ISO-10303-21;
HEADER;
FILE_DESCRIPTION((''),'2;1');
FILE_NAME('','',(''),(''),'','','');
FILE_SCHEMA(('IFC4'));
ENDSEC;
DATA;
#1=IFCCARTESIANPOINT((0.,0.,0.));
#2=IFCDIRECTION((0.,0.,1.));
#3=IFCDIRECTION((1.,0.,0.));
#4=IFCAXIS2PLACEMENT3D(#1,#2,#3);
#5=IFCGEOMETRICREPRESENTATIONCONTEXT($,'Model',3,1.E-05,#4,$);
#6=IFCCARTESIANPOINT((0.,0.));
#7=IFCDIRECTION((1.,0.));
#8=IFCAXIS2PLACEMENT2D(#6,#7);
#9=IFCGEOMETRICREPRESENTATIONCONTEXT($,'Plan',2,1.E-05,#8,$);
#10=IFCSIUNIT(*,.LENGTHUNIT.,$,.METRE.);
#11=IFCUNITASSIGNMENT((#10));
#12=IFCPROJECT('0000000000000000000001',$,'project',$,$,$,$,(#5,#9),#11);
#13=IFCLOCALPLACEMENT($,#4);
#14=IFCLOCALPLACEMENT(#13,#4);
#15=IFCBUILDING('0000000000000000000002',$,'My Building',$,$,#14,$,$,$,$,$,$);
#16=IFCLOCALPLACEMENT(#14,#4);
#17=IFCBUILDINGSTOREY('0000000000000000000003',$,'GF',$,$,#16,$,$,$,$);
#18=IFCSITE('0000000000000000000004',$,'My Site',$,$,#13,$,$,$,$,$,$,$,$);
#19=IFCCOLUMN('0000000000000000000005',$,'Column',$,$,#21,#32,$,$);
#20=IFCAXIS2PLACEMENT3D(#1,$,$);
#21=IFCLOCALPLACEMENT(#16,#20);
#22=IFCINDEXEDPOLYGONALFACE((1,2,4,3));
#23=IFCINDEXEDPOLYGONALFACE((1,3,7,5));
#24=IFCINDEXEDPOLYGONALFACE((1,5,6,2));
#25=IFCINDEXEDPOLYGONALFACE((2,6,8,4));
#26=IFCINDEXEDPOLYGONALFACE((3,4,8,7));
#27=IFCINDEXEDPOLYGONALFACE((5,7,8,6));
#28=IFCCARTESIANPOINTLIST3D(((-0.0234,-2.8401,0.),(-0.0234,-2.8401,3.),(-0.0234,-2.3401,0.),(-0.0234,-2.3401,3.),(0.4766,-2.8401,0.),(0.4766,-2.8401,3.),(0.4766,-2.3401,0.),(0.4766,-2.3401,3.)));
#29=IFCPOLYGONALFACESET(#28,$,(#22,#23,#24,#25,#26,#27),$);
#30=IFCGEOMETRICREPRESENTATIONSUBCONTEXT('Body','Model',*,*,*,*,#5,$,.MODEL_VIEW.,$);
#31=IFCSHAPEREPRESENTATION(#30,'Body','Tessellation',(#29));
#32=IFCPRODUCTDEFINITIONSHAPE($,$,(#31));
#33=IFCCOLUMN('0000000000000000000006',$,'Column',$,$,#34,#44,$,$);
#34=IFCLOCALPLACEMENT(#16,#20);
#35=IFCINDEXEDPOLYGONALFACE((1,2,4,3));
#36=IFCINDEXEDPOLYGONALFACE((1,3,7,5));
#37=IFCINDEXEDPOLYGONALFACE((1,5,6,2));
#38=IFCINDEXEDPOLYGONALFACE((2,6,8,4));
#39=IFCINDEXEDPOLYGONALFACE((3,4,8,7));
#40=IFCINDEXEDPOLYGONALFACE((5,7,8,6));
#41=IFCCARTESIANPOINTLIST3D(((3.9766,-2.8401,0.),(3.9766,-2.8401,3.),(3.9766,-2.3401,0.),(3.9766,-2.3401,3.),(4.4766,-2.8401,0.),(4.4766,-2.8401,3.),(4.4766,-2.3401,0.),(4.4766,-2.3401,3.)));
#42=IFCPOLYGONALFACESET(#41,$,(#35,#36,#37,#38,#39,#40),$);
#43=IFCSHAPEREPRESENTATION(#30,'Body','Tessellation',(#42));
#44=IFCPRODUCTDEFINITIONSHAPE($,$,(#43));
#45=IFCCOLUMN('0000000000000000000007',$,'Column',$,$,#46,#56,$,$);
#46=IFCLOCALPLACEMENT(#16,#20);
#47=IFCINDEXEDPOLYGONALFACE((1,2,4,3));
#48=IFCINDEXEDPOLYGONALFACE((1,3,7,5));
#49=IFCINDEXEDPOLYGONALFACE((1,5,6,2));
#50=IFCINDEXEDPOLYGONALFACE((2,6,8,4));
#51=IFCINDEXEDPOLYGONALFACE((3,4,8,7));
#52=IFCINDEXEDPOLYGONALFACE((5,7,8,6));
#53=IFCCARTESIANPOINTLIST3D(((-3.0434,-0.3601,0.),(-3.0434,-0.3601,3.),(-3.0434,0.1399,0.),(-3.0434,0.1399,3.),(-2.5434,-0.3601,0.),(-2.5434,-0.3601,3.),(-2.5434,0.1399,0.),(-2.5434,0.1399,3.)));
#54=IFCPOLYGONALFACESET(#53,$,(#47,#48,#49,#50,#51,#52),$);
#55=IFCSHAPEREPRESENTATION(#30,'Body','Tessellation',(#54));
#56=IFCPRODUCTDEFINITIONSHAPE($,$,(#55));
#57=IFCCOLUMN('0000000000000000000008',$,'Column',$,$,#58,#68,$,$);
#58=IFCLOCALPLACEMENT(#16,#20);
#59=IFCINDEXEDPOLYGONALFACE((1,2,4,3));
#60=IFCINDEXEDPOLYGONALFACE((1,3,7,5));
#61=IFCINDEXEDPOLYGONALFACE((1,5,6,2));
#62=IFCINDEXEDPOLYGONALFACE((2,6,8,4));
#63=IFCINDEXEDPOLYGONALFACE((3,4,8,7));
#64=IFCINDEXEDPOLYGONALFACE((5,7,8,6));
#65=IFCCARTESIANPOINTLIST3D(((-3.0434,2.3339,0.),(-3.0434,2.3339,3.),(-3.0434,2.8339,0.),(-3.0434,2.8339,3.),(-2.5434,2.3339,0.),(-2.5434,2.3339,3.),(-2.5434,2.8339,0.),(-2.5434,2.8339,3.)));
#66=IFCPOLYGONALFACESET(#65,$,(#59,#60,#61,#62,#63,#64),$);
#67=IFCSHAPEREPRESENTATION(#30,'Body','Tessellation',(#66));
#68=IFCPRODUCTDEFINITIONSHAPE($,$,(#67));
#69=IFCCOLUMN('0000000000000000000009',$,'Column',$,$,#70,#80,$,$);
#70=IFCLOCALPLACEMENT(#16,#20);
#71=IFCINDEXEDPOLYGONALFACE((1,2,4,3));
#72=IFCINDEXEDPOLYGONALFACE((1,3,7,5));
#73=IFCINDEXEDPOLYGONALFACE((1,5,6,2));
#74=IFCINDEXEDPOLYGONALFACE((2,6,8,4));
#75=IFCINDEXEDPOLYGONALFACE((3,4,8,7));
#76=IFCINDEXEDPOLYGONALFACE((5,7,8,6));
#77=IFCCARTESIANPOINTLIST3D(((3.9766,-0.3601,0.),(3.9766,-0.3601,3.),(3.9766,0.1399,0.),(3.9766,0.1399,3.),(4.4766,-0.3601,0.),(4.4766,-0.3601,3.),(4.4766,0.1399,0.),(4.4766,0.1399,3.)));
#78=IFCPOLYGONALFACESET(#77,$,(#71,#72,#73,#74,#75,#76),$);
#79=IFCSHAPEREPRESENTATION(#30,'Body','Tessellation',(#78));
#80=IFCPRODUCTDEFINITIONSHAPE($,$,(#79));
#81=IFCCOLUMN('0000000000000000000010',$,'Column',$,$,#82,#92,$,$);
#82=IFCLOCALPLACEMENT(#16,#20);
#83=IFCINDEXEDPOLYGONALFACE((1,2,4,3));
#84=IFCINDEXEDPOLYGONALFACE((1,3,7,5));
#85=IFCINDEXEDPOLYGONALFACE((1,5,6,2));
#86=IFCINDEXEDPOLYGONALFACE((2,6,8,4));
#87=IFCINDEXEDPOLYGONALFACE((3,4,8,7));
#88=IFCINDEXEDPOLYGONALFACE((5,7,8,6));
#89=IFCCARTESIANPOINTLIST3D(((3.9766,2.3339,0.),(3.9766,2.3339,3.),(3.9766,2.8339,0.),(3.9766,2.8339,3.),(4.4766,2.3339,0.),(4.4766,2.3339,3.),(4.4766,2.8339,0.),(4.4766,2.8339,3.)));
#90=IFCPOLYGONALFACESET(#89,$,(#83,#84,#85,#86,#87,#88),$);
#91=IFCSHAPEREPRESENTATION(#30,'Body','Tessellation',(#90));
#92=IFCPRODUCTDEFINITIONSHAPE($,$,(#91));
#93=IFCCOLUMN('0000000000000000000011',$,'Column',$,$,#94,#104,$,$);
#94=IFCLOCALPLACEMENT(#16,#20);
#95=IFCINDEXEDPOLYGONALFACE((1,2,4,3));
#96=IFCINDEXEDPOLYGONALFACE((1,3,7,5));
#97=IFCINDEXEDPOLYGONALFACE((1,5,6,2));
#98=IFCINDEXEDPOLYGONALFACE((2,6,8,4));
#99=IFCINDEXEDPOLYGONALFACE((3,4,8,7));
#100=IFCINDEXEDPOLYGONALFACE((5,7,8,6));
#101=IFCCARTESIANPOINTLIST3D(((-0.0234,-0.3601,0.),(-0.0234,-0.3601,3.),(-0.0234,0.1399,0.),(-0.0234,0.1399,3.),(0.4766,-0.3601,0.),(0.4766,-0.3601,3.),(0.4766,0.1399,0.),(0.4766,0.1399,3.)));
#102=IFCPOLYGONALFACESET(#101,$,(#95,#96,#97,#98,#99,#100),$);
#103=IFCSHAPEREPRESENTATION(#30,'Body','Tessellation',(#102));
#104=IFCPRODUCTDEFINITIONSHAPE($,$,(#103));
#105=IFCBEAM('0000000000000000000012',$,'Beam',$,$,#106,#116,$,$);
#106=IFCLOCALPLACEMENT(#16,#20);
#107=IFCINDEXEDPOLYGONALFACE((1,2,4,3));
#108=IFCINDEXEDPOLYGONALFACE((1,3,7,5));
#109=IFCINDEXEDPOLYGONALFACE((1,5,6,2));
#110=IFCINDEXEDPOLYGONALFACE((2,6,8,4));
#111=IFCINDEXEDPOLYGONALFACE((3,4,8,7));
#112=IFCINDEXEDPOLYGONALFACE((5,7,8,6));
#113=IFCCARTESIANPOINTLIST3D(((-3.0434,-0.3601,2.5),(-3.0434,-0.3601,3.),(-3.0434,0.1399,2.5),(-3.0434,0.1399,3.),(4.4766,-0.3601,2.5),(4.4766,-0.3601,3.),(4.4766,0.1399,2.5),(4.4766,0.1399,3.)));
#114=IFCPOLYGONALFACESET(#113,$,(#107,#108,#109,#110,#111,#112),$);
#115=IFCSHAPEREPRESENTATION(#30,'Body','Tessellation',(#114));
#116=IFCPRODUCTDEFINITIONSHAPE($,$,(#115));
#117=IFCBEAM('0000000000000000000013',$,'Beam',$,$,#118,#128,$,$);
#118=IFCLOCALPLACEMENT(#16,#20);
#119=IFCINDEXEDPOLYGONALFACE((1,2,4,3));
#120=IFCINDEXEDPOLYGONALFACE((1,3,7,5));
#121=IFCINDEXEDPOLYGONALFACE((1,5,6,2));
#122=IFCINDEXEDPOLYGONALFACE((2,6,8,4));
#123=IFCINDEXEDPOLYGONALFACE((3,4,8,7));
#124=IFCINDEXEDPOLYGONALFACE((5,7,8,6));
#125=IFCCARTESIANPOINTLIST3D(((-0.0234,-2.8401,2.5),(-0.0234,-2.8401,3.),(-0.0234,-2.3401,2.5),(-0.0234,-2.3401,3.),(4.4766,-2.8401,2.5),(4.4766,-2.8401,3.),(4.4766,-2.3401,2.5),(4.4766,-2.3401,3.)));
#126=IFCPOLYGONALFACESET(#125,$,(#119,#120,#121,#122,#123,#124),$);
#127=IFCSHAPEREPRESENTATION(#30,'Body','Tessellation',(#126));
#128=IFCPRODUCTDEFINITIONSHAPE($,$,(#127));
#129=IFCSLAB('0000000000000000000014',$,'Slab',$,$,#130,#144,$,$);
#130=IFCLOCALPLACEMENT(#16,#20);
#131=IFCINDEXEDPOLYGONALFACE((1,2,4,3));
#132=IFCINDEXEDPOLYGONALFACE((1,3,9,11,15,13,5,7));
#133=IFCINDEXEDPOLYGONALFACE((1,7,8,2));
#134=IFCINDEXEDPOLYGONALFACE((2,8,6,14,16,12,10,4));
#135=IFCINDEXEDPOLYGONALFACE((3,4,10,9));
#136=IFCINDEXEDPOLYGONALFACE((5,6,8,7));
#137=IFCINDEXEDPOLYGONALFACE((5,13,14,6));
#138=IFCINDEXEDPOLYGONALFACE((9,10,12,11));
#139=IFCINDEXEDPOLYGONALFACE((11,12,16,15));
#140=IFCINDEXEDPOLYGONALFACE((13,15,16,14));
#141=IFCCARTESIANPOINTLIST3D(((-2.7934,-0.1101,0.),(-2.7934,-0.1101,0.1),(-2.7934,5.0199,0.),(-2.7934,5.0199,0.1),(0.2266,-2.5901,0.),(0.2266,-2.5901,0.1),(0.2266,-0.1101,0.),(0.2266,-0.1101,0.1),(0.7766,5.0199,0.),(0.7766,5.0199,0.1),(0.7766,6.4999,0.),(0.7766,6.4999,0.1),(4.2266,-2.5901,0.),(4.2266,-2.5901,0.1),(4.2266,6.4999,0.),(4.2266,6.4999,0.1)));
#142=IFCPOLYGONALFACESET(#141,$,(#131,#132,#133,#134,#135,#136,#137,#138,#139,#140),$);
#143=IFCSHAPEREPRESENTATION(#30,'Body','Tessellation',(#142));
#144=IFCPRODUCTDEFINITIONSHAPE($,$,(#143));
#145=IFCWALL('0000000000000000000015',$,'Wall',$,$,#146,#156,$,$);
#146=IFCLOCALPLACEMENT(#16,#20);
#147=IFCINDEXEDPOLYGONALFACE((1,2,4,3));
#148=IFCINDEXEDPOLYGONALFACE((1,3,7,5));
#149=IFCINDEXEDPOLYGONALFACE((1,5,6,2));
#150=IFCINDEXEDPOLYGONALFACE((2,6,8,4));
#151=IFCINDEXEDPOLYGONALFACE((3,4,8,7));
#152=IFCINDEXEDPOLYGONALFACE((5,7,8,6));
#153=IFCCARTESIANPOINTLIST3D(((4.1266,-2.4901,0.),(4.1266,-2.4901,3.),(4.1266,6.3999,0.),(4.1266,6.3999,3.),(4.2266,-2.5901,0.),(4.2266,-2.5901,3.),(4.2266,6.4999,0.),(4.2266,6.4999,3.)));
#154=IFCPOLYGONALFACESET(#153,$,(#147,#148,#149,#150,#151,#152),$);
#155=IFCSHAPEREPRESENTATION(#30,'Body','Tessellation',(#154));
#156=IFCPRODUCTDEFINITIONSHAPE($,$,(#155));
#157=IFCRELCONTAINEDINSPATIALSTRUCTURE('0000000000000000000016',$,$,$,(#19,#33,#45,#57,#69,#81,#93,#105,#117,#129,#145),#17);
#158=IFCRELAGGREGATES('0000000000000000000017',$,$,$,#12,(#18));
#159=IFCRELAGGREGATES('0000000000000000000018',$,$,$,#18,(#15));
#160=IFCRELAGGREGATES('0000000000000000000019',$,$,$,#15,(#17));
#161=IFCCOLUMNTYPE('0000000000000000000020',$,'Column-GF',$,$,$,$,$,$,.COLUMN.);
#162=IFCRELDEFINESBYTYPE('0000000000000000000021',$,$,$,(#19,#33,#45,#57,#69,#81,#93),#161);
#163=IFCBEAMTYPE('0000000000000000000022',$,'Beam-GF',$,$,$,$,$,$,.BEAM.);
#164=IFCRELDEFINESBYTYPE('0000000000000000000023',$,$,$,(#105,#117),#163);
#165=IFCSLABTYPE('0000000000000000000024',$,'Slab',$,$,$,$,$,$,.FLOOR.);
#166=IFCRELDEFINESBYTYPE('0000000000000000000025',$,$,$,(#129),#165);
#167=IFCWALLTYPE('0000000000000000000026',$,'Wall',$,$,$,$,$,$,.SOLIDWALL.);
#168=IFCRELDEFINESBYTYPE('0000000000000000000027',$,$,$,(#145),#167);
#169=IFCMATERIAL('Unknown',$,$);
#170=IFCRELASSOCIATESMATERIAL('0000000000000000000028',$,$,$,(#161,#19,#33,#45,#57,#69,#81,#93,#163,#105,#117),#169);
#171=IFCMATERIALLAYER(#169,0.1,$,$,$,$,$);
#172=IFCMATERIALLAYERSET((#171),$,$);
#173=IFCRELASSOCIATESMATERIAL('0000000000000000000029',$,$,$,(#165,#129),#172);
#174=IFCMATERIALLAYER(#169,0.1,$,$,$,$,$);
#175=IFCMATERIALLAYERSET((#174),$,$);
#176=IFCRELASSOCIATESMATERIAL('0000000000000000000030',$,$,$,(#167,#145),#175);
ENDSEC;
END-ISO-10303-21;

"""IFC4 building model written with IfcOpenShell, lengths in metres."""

from ifc_helpers import new_model, si_unit, frame, origin_with_axes, origin_2d_with_axis, place, context, subcontext, project, spatial, line, indexed_curve, rectangle, outline, extrude, material, layer, layer_set, layer_usage, material_profile, profile_set, profile_usage, type_object, element, save


model = new_model("IFC4")

# Units and contexts
model_context = context("Model", 3, precision=1e-05, world=origin_with_axes())
plan_context = context("Plan", 2, precision=1e-05, world=origin_2d_with_axis())
body_context_1 = subcontext(model_context, "Body", "Model", "MODEL_VIEW")
ifc_project = project(units=[si_unit("LENGTHUNIT", "METRE")], contexts=[model_context, plan_context])

# Site, building, storey
site_placement = place(None, origin_with_axes())
site = spatial("IfcSite", under=ifc_project, at=site_placement, Name="My Site")
building_placement = place(site_placement, origin_with_axes())
building = spatial("IfcBuilding", under=site, at=building_placement, Name="My Building")
storey_placement = place(building_placement, origin_with_axes())
storey = spatial("IfcBuildingStorey", under=building, at=storey_placement, Name="GF")

# Columns
ifc_material = material(Name="Unknown")
ifc_material_profile_1 = material_profile(ifc_material, rectangle(XDim=0.5, YDim=0.5))
ifc_profile_set_1 = profile_set([ifc_material_profile_1])
ifc_profile_usage_1 = profile_usage(ifc_profile_set_1, cardinal=5)
column_type = type_object("IfcColumnType", Name="Column-GF", PredefinedType="COLUMN", material=ifc_profile_set_1)
column_1_placement = place(storey_placement, frame((0.2266, -2.5901, 0.0), z_axis=(0.0, 0.0, 1.0), x_axis=(1.0, 0.0, 0.0)))
element("IfcColumn", 1, at=column_1_placement, inside=storey, type_object=column_type, material=ifc_profile_usage_1, Name="Column", context=body_context_1, shape_type="SweptSolid", body=[
    extrude(rectangle(XDim=0.5, YDim=0.5), origin_with_axes(), (0.0, 0.0, 1.0), 3.0),
])
ifc_profile_usage_2 = profile_usage(ifc_profile_set_1, cardinal=5)
column_2_placement = place(storey_placement, frame((4.2266, -2.5901, 0.0), z_axis=(0.0, 0.0, 1.0), x_axis=(1.0, 0.0, 0.0)))
element("IfcColumn", 2, at=column_2_placement, inside=storey, type_object=column_type, material=ifc_profile_usage_2, Name="Column", context=body_context_1, shape_type="SweptSolid", body=[
    extrude(rectangle(XDim=0.5, YDim=0.5), origin_with_axes(), (0.0, 0.0, 1.0), 3.0),
])
ifc_profile_usage_3 = profile_usage(ifc_profile_set_1, cardinal=5)
column_3_placement = place(storey_placement, frame((-2.7934, -0.1101, 0.0), z_axis=(0.0, 0.0, 1.0), x_axis=(1.0, 0.0, 0.0)))
element("IfcColumn", 3, at=column_3_placement, inside=storey, type_object=column_type, material=ifc_profile_usage_3, Name="Column", context=body_context_1, shape_type="SweptSolid", body=[
    extrude(rectangle(XDim=0.5, YDim=0.5), origin_with_axes(), (0.0, 0.0, 1.0), 3.0),
])
ifc_profile_usage_4 = profile_usage(ifc_profile_set_1, cardinal=5)
column_4_placement = place(storey_placement, frame((-2.7934, 2.5839, 0.0), z_axis=(0.0, 0.0, 1.0), x_axis=(1.0, 0.0, 0.0)))
element("IfcColumn", 4, at=column_4_placement, inside=storey, type_object=column_type, material=ifc_profile_usage_4, Name="Column", context=body_context_1, shape_type="SweptSolid", body=[
    extrude(rectangle(XDim=0.5, YDim=0.5), origin_with_axes(), (0.0, 0.0, 1.0), 3.0),
])
ifc_profile_usage_5 = profile_usage(ifc_profile_set_1, cardinal=5)
column_5_placement = place(storey_placement, frame((4.2266, -0.1101, 0.0), z_axis=(0.0, 0.0, 1.0), x_axis=(1.0, 0.0, 0.0)))
element("IfcColumn", 5, at=column_5_placement, inside=storey, type_object=column_type, material=ifc_profile_usage_5, Name="Column", context=body_context_1, shape_type="SweptSolid", body=[
    extrude(rectangle(XDim=0.5, YDim=0.5), origin_with_axes(), (0.0, 0.0, 1.0), 3.0),
])
ifc_profile_usage_6 = profile_usage(ifc_profile_set_1, cardinal=5)
column_6_placement = place(storey_placement, frame((4.2266, 2.5839, 0.0), z_axis=(0.0, 0.0, 1.0), x_axis=(1.0, 0.0, 0.0)))
element("IfcColumn", 6, at=column_6_placement, inside=storey, type_object=column_type, material=ifc_profile_usage_6, Name="Column", context=body_context_1, shape_type="SweptSolid", body=[
    extrude(rectangle(XDim=0.5, YDim=0.5), origin_with_axes(), (0.0, 0.0, 1.0), 3.0),
])
ifc_profile_usage_7 = profile_usage(ifc_profile_set_1, cardinal=5)
column_7_placement = place(storey_placement, frame((0.2266, -0.1101, 0.0), z_axis=(0.0, 0.0, 1.0), x_axis=(1.0, 0.0, 0.0)))
element("IfcColumn", 7, at=column_7_placement, inside=storey, type_object=column_type, material=ifc_profile_usage_7, Name="Column", context=body_context_1, shape_type="SweptSolid", body=[
    extrude(rectangle(XDim=0.5, YDim=0.5), origin_with_axes(), (0.0, 0.0, 1.0), 3.0),
])

# Beams
ifc_material_profile_2 = material_profile(ifc_material, rectangle(XDim=0.5, YDim=0.5))
ifc_profile_set_2 = profile_set([ifc_material_profile_2])
ifc_profile_usage_8 = profile_usage(ifc_profile_set_2, cardinal=7)
beam_type = type_object("IfcBeamType", Name="Beam-GF", PredefinedType="BEAM", material=ifc_profile_set_2)
beam_1_placement = place(storey_placement, frame((-3.0434, 0.1399, 3.0), z_axis=(1.0, 0.0, 0.0), x_axis=(0.0, 1.0, 0.0)))
element("IfcBeam", 8, at=beam_1_placement, inside=storey, type_object=beam_type, material=ifc_profile_usage_8, Name="Beam", context=body_context_1, shape_type="SweptSolid", body=[
    extrude(rectangle(XDim=0.5, YDim=0.5), frame((-0.25, -0.25, 0.0), z_axis=(0.0, 0.0, 1.0), x_axis=(1.0, 0.0, 0.0)), (0.0, 0.0, 1.0), 7.52),
])
ifc_profile_usage_9 = profile_usage(ifc_profile_set_2, cardinal=7)
beam_2_placement = place(storey_placement, frame((-0.0234, -2.3401, 3.0), z_axis=(1.0, -0.000001, 0.000001), x_axis=(0.000001, 1.0, 0.0)))
element("IfcBeam", 9, at=beam_2_placement, inside=storey, type_object=beam_type, material=ifc_profile_usage_9, Name="Beam", context=body_context_1, shape_type="SweptSolid", body=[
    extrude(rectangle(XDim=0.5, YDim=0.5), frame((-0.25, -0.25, 0.0), z_axis=(0.0, 0.0, 1.0), x_axis=(1.0, 0.0, 0.0)), (0.0, 0.0, 1.0), 4.5),
])

# Slab
ifc_layer_1 = layer(ifc_material, 0.1)
ifc_layer_set_1 = layer_set([ifc_layer_1])
ifc_layer_usage_1 = layer_usage(ifc_layer_set_1, "AXIS3", "POSITIVE", -0.1)
slab_type_1 = type_object("IfcSlabType", Name="Slab", PredefinedType="FLOOR", material=ifc_layer_set_1)
slab_1_placement = place(storey_placement, frame((4.2266, -2.5901, 0.1), z_axis=(0.0, 0.0, 1.0), x_axis=(1.0, 0.0, 0.0)))
element("IfcSlab", 10, at=slab_1_placement, inside=storey, type_object=slab_type_1, material=ifc_layer_usage_1, Name="Slab", context=body_context_1, shape_type="SweptSolid", body=[
    extrude(outline(indexed_curve([(0.0, 0.0), (0.0, 9.09), (-3.45, 9.09), (-3.45, 7.61), (-7.02, 7.61), (-7.02, 2.48), (-4.0, 2.48), (-4.0, 0.0), (0.0, 0.0)])), frame((0.0, 0.0, -0.1), z_axis=(0.0, 0.0, 1.0), x_axis=(1.0, 0.0, 0.0)), (0.0, 0.0, 1.0), 0.1),
])

# Shared definitions
ifc_layer_2 = layer(ifc_material, 0.1)
ifc_layer_set_2 = layer_set([ifc_layer_2])
wall_type = type_object("IfcWallType", Name="Wall", PredefinedType="SOLIDWALL", material=ifc_layer_set_2)

# Wall
ifc_layer_usage_2 = layer_usage(ifc_layer_set_2, "AXIS2", "POSITIVE", 0.0)
wall_1_placement = place(storey_placement, frame((4.2266, -2.5901, 0.0), z_axis=(0.0, 0.0, 1.0), x_axis=(0.0, 1.0, 0.0)))
element("IfcWall", 11, at=wall_1_placement, inside=storey, type_object=wall_type, material=ifc_layer_usage_2, Name="Wall", context=body_context_1, shape_type="SweptSolid", body=[
    extrude(outline(indexed_curve([(0.0, 0.0), (0.1, 0.1), (8.99, 0.1), (9.09, 0.0)], segments=[line(1, 2, 3, 4, 1)])), origin_with_axes(), (0.0, 0.0, 1.0), 3.0),
])

save(model, "model.ifc")
